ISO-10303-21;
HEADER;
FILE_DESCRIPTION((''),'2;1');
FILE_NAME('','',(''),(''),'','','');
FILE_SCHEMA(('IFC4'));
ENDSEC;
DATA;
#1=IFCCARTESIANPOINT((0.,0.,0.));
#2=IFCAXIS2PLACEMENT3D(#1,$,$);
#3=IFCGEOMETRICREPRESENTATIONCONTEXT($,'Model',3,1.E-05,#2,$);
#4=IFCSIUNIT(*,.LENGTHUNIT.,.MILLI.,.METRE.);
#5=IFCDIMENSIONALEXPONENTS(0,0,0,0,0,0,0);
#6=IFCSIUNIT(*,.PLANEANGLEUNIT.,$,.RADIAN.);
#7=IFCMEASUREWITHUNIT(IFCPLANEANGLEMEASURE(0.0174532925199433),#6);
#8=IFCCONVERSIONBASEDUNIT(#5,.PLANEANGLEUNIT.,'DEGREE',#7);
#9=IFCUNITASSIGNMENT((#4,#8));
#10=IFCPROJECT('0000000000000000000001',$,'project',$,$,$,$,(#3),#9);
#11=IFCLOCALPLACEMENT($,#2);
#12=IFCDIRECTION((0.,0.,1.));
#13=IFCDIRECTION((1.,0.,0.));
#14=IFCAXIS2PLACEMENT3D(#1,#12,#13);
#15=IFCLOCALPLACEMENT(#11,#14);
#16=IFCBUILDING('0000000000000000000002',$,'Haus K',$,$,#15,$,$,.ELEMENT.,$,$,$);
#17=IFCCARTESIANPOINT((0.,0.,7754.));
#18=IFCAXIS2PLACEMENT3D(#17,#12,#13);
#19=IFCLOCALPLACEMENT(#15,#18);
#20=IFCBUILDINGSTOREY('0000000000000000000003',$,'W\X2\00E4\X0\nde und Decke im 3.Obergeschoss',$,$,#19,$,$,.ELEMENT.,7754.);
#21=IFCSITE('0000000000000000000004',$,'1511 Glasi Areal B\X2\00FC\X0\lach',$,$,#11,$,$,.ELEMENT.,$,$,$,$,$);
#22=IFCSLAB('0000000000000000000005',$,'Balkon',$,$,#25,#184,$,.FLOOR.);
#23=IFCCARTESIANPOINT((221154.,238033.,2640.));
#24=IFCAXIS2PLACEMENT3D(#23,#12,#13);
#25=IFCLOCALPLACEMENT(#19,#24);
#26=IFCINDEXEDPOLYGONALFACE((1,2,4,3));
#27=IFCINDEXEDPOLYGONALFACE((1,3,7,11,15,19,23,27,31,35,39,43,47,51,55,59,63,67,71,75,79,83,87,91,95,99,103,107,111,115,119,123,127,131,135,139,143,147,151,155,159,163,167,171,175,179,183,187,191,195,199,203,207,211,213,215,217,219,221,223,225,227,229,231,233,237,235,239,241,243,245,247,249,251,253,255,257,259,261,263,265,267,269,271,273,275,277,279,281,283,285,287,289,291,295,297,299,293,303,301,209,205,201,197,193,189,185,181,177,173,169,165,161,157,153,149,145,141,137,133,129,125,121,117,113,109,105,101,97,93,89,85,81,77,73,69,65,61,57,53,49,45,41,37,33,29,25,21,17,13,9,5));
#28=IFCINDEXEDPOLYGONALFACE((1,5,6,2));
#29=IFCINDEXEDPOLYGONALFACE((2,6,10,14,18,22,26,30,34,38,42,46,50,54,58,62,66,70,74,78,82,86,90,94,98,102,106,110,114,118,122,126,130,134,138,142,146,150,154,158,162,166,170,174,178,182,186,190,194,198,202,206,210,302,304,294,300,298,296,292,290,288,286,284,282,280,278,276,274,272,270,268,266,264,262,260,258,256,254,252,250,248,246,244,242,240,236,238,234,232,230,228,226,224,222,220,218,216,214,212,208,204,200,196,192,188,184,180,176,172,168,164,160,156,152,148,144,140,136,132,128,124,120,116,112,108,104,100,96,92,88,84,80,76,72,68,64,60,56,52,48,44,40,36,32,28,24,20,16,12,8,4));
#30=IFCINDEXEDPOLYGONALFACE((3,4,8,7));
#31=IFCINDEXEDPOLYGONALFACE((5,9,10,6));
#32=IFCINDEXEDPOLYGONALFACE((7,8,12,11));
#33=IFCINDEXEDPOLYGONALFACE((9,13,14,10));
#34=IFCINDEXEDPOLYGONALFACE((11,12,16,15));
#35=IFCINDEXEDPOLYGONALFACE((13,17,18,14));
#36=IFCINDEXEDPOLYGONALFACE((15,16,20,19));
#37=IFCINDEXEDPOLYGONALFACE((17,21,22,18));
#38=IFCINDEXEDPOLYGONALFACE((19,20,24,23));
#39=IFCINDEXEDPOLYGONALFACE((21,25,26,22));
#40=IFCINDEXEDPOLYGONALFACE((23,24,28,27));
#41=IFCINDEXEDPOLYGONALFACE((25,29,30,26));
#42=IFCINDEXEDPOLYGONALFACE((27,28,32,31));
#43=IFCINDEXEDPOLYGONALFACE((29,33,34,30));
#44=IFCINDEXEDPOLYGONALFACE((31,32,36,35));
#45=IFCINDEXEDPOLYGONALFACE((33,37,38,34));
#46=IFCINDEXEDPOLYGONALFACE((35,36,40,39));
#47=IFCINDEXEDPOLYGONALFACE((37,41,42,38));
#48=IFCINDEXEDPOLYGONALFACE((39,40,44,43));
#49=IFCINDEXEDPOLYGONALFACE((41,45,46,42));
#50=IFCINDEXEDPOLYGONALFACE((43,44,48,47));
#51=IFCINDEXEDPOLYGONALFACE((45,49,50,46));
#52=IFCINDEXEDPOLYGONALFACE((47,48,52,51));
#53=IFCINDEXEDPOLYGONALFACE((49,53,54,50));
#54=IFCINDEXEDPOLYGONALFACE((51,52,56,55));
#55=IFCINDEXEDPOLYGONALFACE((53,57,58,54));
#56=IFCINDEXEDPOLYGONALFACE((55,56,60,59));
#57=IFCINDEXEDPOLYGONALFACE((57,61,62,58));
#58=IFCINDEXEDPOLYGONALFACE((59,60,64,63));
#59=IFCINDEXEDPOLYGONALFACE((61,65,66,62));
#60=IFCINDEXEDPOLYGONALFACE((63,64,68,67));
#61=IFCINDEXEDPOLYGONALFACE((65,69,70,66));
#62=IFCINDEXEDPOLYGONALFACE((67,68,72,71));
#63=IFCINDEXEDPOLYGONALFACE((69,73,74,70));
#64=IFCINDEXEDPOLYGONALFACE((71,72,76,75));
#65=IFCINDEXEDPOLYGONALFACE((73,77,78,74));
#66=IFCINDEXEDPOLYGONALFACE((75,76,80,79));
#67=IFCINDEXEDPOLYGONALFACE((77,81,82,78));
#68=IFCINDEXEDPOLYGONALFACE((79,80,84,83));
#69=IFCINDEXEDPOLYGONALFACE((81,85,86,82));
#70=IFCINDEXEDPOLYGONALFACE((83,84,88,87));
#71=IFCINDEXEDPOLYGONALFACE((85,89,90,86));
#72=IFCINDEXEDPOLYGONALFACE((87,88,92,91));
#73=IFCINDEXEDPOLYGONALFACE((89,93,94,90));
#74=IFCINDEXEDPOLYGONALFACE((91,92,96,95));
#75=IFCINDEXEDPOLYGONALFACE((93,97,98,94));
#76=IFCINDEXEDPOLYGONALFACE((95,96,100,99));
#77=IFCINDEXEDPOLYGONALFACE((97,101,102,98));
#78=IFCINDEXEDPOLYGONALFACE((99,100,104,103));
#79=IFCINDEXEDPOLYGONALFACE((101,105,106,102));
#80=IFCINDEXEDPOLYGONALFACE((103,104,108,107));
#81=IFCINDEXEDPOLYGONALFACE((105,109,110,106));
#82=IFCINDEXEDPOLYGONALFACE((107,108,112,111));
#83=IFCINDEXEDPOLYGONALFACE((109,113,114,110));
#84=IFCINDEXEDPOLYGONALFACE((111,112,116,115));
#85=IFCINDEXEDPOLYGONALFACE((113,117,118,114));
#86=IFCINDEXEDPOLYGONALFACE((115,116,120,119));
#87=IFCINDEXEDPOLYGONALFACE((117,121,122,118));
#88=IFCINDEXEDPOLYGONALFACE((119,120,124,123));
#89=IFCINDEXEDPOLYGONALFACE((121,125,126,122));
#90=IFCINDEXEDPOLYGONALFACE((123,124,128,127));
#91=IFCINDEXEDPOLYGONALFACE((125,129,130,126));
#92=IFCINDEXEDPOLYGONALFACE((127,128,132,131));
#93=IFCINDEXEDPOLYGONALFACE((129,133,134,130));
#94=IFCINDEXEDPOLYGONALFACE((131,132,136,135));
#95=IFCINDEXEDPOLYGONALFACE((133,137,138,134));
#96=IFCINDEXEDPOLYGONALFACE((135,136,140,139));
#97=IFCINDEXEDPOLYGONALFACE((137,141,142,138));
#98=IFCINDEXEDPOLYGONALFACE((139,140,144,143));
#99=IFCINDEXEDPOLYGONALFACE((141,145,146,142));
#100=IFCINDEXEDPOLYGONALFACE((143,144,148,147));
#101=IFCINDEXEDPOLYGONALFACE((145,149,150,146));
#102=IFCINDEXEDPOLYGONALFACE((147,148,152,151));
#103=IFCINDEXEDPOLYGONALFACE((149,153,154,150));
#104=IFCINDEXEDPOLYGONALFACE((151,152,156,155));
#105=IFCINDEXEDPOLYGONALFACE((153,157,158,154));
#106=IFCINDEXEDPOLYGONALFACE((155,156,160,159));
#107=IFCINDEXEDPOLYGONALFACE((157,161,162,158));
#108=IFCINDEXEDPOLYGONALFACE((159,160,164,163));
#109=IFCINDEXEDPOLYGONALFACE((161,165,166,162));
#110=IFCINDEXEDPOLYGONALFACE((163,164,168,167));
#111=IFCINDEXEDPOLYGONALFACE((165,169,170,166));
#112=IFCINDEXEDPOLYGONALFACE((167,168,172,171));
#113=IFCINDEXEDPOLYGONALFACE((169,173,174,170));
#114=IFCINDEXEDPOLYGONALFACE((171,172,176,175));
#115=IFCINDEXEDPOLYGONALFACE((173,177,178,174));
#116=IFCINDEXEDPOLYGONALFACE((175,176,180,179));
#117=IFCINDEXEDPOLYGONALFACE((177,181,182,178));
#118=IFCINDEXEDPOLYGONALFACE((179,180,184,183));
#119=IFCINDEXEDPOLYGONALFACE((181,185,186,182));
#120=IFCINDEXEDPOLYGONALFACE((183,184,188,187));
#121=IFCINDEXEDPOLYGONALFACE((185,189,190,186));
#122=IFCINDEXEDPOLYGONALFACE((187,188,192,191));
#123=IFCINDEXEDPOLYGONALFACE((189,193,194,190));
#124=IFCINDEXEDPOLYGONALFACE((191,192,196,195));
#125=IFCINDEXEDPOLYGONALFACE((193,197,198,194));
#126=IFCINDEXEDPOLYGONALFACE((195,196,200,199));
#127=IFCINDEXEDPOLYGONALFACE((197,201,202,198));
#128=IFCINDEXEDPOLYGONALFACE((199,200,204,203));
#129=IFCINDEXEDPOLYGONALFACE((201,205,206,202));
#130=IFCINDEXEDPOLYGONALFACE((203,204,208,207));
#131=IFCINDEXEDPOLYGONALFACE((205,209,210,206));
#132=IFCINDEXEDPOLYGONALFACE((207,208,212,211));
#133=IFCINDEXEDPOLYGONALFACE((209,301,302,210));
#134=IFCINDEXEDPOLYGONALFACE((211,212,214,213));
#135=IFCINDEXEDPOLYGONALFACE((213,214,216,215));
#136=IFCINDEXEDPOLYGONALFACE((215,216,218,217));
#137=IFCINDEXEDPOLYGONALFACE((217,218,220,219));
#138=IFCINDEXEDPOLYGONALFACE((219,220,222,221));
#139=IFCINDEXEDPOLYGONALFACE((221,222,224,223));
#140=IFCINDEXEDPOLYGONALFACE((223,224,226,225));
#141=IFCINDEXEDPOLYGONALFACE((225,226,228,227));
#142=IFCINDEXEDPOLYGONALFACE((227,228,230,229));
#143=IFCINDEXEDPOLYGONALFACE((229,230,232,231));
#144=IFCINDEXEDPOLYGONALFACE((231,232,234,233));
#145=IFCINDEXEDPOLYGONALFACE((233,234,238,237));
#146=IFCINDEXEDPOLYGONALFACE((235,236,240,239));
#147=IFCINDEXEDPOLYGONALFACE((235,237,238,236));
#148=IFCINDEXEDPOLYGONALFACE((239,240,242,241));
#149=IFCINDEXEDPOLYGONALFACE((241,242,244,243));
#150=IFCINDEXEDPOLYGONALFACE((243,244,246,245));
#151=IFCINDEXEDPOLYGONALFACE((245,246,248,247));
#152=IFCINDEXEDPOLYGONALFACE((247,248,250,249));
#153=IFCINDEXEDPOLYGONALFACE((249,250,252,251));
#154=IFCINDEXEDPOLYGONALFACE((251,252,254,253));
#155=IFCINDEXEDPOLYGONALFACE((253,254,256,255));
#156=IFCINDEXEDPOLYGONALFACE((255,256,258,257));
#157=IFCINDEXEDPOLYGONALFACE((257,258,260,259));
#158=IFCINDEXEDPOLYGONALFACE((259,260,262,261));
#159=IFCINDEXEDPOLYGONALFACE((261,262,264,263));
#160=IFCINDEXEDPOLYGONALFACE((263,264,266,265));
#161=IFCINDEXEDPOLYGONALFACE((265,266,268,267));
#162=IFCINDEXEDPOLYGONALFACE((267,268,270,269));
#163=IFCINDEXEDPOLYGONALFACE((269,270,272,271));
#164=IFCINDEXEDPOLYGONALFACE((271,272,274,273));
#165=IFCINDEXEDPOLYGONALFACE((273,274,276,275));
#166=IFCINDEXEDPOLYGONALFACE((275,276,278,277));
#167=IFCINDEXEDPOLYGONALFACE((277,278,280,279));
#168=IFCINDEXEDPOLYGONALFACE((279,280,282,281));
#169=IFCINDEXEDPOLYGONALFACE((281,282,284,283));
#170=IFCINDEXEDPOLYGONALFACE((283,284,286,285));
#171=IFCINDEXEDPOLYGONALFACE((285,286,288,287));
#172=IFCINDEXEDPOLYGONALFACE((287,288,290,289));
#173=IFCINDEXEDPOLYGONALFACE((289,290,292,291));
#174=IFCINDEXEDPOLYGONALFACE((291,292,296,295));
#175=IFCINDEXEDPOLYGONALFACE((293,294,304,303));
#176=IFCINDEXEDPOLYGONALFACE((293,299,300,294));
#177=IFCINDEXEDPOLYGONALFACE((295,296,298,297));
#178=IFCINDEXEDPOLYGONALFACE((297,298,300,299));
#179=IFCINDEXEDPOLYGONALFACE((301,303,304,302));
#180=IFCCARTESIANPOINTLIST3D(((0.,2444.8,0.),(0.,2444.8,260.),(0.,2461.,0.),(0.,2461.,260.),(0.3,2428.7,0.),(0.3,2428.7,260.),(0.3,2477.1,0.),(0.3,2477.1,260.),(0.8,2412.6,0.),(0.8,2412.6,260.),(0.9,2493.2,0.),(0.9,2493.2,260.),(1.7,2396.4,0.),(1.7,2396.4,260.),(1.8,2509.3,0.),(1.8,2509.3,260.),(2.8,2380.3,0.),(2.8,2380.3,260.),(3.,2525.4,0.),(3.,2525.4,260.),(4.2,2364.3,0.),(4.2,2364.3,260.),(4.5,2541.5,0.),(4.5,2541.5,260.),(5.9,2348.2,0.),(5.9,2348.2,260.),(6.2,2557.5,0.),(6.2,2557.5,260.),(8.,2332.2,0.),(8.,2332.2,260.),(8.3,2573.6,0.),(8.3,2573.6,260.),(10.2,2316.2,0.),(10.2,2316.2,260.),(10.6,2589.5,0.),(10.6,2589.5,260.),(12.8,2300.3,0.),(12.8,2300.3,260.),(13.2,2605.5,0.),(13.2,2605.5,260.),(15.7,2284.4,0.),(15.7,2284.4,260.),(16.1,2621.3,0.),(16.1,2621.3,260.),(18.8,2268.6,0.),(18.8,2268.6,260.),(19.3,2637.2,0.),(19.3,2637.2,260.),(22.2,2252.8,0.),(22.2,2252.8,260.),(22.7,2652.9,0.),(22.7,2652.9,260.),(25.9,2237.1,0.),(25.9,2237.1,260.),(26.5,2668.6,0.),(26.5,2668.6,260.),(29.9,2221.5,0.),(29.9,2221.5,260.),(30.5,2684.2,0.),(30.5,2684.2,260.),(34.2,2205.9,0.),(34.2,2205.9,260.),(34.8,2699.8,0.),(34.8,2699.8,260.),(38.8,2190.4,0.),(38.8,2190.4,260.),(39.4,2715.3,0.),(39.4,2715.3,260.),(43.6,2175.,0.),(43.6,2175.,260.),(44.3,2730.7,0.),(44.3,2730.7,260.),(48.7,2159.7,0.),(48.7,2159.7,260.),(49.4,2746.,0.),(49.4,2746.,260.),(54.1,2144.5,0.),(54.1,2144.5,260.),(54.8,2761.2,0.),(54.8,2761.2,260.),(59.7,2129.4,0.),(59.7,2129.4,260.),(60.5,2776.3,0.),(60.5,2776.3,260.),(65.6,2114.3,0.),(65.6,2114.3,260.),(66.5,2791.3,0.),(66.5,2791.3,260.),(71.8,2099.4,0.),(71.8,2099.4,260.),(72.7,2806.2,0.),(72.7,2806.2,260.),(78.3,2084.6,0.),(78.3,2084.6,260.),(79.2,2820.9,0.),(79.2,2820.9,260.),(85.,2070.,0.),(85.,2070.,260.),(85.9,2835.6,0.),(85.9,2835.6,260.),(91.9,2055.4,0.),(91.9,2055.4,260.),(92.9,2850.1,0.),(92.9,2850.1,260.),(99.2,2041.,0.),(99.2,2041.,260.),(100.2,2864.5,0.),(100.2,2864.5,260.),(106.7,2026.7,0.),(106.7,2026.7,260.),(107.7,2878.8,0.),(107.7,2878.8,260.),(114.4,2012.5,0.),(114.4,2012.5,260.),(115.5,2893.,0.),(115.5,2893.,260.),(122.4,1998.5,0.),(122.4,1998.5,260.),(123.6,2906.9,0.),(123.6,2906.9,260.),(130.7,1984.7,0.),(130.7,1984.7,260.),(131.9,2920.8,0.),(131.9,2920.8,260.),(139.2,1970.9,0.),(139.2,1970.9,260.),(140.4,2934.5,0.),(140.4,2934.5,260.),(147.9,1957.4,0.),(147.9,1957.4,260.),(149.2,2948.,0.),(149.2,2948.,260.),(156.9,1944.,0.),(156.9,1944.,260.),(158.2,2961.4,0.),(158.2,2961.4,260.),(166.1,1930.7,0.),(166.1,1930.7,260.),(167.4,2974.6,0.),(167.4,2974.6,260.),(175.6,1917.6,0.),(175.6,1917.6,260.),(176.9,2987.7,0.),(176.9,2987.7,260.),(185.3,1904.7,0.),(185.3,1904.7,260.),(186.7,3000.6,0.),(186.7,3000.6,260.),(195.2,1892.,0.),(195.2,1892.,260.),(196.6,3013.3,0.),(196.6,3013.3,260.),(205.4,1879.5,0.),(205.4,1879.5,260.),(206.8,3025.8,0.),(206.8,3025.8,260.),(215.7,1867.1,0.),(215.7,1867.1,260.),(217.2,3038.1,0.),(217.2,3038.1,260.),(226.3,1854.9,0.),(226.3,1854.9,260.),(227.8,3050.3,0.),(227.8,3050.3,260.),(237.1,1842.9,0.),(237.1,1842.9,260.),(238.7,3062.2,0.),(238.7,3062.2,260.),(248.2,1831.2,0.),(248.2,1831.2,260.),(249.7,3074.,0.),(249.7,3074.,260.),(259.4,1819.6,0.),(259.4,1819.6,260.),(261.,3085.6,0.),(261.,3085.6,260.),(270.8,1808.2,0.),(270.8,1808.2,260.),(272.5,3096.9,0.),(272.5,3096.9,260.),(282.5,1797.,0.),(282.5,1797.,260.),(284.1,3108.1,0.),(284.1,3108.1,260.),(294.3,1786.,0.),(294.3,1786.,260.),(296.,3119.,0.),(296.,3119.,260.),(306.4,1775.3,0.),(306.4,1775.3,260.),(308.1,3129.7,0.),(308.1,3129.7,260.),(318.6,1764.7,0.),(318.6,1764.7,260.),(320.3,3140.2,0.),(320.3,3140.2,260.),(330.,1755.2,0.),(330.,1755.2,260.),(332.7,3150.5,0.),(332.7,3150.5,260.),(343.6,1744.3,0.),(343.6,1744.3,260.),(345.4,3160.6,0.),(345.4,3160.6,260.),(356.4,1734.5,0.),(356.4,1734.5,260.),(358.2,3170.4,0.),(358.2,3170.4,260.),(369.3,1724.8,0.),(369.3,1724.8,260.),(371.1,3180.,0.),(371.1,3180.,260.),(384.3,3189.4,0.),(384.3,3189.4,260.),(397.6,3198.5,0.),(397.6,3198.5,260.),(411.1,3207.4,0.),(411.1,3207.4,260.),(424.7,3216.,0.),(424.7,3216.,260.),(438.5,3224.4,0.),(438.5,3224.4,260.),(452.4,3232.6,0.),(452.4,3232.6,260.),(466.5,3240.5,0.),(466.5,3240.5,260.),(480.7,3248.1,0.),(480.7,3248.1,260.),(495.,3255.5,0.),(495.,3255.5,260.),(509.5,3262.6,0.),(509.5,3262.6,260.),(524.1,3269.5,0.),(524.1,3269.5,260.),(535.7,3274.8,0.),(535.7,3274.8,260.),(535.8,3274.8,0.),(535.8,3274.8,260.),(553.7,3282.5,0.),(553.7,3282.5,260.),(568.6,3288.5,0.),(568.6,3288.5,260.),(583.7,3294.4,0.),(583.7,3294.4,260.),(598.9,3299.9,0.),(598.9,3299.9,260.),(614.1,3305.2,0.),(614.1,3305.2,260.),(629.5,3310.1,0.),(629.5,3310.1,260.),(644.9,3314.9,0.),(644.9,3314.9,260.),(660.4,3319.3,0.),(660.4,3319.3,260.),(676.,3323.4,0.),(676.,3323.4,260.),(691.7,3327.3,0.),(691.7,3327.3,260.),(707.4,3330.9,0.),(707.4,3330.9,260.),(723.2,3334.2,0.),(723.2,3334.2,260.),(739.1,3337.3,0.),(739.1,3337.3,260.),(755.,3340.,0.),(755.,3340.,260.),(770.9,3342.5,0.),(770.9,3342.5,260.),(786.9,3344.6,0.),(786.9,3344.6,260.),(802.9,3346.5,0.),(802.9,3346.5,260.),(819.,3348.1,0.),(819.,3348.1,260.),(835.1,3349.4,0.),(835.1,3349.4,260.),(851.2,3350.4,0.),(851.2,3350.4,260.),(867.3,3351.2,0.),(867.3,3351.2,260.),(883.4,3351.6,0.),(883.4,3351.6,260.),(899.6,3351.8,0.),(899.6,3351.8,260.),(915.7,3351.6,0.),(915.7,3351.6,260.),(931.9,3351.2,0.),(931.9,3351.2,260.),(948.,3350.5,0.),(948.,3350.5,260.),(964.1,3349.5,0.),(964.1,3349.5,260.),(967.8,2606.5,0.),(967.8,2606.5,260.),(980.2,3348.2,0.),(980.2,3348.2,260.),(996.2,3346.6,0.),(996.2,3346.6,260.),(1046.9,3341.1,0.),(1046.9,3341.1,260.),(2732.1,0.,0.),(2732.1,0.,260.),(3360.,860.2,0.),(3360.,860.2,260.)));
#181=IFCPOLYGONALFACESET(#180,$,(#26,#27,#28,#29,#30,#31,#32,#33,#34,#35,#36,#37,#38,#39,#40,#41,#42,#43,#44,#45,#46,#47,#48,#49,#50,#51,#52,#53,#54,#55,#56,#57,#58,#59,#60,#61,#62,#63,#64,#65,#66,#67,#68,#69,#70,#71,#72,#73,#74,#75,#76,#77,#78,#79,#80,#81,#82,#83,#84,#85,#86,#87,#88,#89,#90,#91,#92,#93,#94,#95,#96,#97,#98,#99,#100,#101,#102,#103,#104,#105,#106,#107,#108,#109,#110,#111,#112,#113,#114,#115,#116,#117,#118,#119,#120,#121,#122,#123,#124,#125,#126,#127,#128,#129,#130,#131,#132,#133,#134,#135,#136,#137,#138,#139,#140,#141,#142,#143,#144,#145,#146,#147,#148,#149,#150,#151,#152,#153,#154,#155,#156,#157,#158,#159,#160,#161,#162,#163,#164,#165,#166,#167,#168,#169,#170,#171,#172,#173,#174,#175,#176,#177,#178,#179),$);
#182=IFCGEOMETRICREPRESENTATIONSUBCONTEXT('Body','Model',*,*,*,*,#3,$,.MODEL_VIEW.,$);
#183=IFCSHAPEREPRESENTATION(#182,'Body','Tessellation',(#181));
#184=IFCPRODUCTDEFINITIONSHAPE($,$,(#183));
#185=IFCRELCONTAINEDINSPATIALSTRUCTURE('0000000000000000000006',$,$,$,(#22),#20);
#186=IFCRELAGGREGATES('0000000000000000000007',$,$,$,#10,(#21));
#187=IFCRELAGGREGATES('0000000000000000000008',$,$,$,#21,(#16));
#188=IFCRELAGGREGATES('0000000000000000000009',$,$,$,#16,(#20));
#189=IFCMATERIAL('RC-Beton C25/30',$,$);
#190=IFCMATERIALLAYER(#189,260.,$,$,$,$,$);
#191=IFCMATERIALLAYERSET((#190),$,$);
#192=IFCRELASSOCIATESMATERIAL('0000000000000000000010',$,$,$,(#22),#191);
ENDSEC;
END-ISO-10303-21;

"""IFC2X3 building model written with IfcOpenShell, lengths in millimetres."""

from ifc_helpers import new_model, entity, si_unit, converted_unit, frame, origin, origin_with_axes, place, context, subcontext, project, spatial, polyline, outline, extrude, material, layer, layer_set, layer_usage, element, save


model = new_model("IFC2X3")

# Units and contexts
model_context = context("Model", 3, precision=1e-05, world=origin())
body_context = subcontext(model_context, "Body", "Model", "MODEL_VIEW")
ifc_project = project(units=[si_unit("LENGTHUNIT", "METRE", prefix="MILLI"), converted_unit("PLANEANGLEUNIT", "DEGREE", entity("IfcPlaneAngleMeasure", 0.0174532925199433), si_unit("PLANEANGLEUNIT", "RADIAN"), dimensions=[0, 0, 0, 0, 0, 0, 0])], contexts=[model_context])

# Site, building, storey
site_placement = place(None, origin())
site = spatial("IfcSite", under=ifc_project, at=site_placement, Name="1511 Glasi Areal Bülach", CompositionType="ELEMENT")
building_placement = place(site_placement, origin_with_axes())
building = spatial("IfcBuilding", under=site, at=building_placement, Name="Haus K", CompositionType="ELEMENT")
storey_placement = place(building_placement, frame((0.0, 0.0, 7754.0), z_axis=(0.0, 0.0, 1.0), x_axis=(1.0, 0.0, 0.0)))
storey = spatial("IfcBuildingStorey", under=building, at=storey_placement, Name="Wände und Decke im 3.Obergeschoss", CompositionType="ELEMENT", Elevation=7754.0)

# Slab
ifc_material_1 = material(Name="RC-Beton C25/30")
ifc_layer_1 = layer(ifc_material_1, 260.0)
ifc_layer_set_1 = layer_set([ifc_layer_1])
ifc_layer_usage_1 = layer_usage(ifc_layer_set_1, "AXIS3", "POSITIVE", 0.0)
slab_1_placement = place(storey_placement, frame((221154.0, 238033.0, 2640.0), z_axis=(0.0, 0.0, 1.0), x_axis=(1.0, 0.0, 0.0)))
element("IfcSlab", 1, at=slab_1_placement, inside=storey, material=ifc_layer_usage_1, Name="Balkon", PredefinedType="FLOOR", context=body_context, shape_type="SweptSolid", body=[
    extrude(outline(polyline([(996.2, 3346.6), (980.2, 3348.2), (964.1, 3349.5), (948.0, 3350.5), (931.9, 3351.2), (915.7, 3351.6), (899.6, 3351.8), (883.4, 3351.6), (867.3, 3351.2), (851.2, 3350.4), (835.1, 3349.4), (819.0, 3348.1), (802.9, 3346.5), (786.9, 3344.6), (770.9, 3342.5), (755.0, 3340.0), (739.1, 3337.3), (723.2, 3334.2), (707.4, 3330.9), (691.7, 3327.3), (676.0, 3323.4), (660.4, 3319.3), (644.9, 3314.9), (629.5, 3310.1), (614.1, 3305.2), (598.9, 3299.9), (583.7, 3294.4), (568.6, 3288.5), (553.7, 3282.5), (535.7, 3274.8), (535.8, 3274.8), (524.1, 3269.5), (509.5, 3262.6), (495.0, 3255.5), (480.7, 3248.1), (466.5, 3240.5), (452.4, 3232.6), (438.5, 3224.4), (424.7, 3216.0), (411.1, 3207.4), (397.6, 3198.5), (384.3, 3189.4), (371.1, 3180.0), (358.2, 3170.4), (345.4, 3160.6), (332.7, 3150.5), (320.3, 3140.2), (308.1, 3129.7), (296.0, 3119.0), (284.1, 3108.1), (272.5, 3096.9), (261.0, 3085.6), (249.7, 3074.0), (238.7, 3062.2), (227.8, 3050.3), (217.2, 3038.1), (206.8, 3025.8), (196.6, 3013.3), (186.7, 3000.6), (176.9, 2987.7), (167.4, 2974.6), (158.2, 2961.4), (149.2, 2948.0), (140.4, 2934.5), (131.9, 2920.8), (123.6, 2906.9), (115.5, 2893.0), (107.7, 2878.8), (100.2, 2864.5), (92.9, 2850.1), (85.9, 2835.6), (79.2, 2820.9), (72.7, 2806.2), (66.5, 2791.3), (60.5, 2776.3), (54.8, 2761.2), (49.4, 2746.0), (44.3, 2730.7), (39.4, 2715.3), (34.8, 2699.8), (30.5, 2684.2), (26.5, 2668.6), (22.7, 2652.9), (19.3, 2637.2), (16.1, 2621.3), (13.2, 2605.5), (10.6, 2589.5), (8.3, 2573.6), (6.2, 2557.5), (4.5, 2541.5), (3.0, 2525.4), (1.8, 2509.3), (0.9, 2493.2), (0.3, 2477.1), (0.0, 2461.0), (0.0, 2444.8), (0.3, 2428.7), (0.8, 2412.6), (1.7, 2396.4), (2.8, 2380.3), (4.2, 2364.3), (5.9, 2348.2), (8.0, 2332.2), (10.2, 2316.2), (12.8, 2300.3), (15.7, 2284.4), (18.8, 2268.6), (22.2, 2252.8), (25.9, 2237.1), (29.9, 2221.5), (34.2, 2205.9), (38.8, 2190.4), (43.6, 2175.0), (48.7, 2159.7), (54.1, 2144.5), (59.7, 2129.4), (65.6, 2114.3), (71.8, 2099.4), (78.3, 2084.6), (85.0, 2070.0), (91.9, 2055.4), (99.2, 2041.0), (106.7, 2026.7), (114.4, 2012.5), (122.4, 1998.5), (130.7, 1984.7), (139.2, 1970.9), (147.9, 1957.4), (156.9, 1944.0), (166.1, 1930.7), (175.6, 1917.6), (185.3, 1904.7), (195.2, 1892.0), (205.4, 1879.5), (215.7, 1867.1), (226.3, 1854.9), (237.1, 1842.9), (248.2, 1831.2), (259.4, 1819.6), (270.8, 1808.2), (282.5, 1797.0), (294.3, 1786.0), (306.4, 1775.3), (318.6, 1764.7), (330.0, 1755.2), (330.0, 1755.2), (343.6, 1744.3), (356.4, 1734.5), (369.3, 1724.8), (2732.1, 0.0), (3360.0, 860.2), (967.8, 2606.5), (1046.9, 3341.1), (996.2, 3346.6)])), origin_with_axes(), (0.0, 0.0, 1.0), 260.0),
])

save(model, "model.ifc")
